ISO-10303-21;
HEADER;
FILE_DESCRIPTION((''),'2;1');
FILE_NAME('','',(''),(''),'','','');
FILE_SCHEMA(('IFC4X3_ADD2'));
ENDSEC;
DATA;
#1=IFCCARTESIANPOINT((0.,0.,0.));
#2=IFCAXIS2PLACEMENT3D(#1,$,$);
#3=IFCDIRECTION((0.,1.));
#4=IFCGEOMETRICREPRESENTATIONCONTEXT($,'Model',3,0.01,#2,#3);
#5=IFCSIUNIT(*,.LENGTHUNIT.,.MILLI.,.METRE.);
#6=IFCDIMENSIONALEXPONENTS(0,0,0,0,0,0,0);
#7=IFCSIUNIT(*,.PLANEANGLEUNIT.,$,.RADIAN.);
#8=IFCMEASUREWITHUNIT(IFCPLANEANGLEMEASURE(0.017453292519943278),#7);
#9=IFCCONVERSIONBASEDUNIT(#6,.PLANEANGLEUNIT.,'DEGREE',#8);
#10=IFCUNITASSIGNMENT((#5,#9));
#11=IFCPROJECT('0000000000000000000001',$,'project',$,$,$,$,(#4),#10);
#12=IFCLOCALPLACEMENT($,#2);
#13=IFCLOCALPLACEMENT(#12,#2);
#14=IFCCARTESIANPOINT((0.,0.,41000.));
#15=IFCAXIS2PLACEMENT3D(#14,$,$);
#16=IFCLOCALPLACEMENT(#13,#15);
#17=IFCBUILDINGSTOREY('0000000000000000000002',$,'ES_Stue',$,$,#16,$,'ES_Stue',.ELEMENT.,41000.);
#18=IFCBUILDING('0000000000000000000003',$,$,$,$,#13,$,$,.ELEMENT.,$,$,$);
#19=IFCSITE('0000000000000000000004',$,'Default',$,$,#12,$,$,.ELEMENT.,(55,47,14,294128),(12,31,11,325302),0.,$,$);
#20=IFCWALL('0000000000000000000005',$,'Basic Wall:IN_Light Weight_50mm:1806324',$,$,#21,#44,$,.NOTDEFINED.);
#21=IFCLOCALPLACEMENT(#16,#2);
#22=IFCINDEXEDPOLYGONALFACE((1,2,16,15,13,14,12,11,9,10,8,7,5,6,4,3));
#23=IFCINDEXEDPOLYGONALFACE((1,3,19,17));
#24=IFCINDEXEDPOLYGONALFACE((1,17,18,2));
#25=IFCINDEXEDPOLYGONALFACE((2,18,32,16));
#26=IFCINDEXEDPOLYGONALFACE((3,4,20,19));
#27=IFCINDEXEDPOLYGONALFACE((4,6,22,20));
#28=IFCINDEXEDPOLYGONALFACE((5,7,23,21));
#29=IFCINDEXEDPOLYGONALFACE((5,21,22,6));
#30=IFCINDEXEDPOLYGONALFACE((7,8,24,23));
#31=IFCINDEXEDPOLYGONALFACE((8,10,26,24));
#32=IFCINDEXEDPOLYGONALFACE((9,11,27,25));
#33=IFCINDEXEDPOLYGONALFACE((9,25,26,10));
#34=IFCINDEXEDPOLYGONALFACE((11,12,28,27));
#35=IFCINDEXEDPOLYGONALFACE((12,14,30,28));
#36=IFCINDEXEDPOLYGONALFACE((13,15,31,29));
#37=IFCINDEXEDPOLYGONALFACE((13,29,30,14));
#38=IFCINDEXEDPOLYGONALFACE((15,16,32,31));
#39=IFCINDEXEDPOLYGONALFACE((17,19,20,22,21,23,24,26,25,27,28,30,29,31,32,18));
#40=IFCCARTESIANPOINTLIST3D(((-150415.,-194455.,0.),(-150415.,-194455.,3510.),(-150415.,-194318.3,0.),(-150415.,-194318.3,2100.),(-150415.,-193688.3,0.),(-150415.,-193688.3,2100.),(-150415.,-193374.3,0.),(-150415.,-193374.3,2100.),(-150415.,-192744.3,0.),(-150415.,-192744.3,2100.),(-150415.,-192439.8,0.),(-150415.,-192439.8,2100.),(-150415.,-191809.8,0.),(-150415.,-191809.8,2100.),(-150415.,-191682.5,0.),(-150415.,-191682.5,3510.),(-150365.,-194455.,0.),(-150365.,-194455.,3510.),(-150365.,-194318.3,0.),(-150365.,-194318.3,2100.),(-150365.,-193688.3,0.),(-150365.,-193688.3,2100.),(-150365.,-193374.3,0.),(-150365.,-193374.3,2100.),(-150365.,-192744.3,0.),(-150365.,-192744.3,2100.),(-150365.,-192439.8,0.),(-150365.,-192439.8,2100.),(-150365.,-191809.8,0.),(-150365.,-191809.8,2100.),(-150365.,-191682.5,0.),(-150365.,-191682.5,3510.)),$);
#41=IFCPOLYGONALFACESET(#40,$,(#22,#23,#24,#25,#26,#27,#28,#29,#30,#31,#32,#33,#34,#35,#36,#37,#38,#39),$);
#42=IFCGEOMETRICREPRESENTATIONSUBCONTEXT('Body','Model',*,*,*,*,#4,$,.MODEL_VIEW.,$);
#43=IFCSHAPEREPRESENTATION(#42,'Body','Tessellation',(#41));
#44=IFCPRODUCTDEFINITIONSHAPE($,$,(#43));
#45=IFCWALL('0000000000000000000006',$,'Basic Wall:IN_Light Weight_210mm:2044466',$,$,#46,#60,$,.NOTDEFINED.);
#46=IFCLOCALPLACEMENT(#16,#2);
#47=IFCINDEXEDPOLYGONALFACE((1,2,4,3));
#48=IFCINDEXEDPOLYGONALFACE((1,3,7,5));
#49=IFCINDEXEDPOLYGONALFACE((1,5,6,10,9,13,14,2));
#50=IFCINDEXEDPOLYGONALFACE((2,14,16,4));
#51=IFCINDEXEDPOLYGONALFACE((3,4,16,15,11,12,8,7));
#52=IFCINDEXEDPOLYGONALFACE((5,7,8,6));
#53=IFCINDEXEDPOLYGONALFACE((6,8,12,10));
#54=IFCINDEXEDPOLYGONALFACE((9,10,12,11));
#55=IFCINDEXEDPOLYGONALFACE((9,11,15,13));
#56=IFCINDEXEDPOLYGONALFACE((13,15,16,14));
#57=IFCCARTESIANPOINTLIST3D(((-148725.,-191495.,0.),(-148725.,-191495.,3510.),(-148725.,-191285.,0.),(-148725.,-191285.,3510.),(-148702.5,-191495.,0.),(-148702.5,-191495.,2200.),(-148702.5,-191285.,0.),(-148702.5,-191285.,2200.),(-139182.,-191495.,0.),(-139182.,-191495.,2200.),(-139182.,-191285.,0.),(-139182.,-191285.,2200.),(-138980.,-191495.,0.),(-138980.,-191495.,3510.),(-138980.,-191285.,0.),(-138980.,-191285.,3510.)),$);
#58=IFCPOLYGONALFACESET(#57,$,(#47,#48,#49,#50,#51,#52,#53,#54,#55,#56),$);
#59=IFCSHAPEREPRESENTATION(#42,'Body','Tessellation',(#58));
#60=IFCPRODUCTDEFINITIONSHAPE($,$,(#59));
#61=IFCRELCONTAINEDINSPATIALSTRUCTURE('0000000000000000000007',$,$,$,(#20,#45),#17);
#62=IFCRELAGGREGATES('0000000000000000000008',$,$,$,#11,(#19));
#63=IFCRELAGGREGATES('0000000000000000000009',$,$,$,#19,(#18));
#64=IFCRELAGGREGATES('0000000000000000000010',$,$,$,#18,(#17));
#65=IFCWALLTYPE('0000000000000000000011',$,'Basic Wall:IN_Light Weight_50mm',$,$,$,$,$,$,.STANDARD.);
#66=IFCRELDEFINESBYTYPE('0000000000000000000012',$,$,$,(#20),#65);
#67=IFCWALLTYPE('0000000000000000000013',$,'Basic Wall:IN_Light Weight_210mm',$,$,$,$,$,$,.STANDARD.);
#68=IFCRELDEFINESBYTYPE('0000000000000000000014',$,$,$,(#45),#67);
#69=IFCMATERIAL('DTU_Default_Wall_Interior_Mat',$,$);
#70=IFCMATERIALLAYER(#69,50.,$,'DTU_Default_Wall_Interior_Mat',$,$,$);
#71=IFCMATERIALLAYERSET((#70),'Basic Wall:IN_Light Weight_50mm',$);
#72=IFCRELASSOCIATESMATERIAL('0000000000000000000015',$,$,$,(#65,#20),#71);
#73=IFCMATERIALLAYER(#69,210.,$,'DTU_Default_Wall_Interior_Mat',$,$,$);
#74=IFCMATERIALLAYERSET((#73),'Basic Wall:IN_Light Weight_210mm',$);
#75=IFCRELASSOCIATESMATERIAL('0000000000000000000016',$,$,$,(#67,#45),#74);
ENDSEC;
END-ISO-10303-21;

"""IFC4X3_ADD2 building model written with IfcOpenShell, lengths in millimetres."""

from ifc_helpers import new_model, entity, si_unit, converted_unit, direction, frame, frame_2d, origin, place, context, subcontext, project, spatial, rectangle, extrude, material, layer, layer_set, type_object, element, save


model = new_model("IFC4X3_ADD2")

# Units and contexts
model_context = context("Model", 3, precision=0.01, world=origin(), true_north=direction((0.0, 1.0)))
body_context = subcontext(model_context, "Body", "Model", "MODEL_VIEW")
ifc_project = project(units=[si_unit("LENGTHUNIT", "METRE", prefix="MILLI"), converted_unit("PLANEANGLEUNIT", "DEGREE", entity("IfcPlaneAngleMeasure", 0.017453292519943278), si_unit("PLANEANGLEUNIT", "RADIAN"), dimensions=[0, 0, 0, 0, 0, 0, 0])], contexts=[model_context])

# Site, building, storey
site_placement = place(None, origin())
site = spatial("IfcSite", under=ifc_project, at=site_placement, Name="Default", CompositionType="ELEMENT", RefLatitude=(55, 47, 14, 294128), RefLongitude=(12, 31, 11, 325302), RefElevation=0.0)
building_placement = place(site_placement, origin())
building = spatial("IfcBuilding", under=site, at=building_placement, CompositionType="ELEMENT")
storey_placement = place(building_placement, frame((0.0, 0.0, 41000.0)))
storey = spatial("IfcBuildingStorey", under=building, at=storey_placement, Name="ES_Stue", LongName="ES_Stue", CompositionType="ELEMENT", Elevation=41000.0)

# Shared definitions
ifc_material_1 = material(Name="DTU_Default_Wall_Interior_Mat")

# Shared definitions
ifc_layer_1 = layer(ifc_material_1, 50.0, Name="DTU_Default_Wall_Interior_Mat")
ifc_layer_set_1 = layer_set([ifc_layer_1], Name="Basic Wall:IN_Light Weight_50mm")
wall_type_1 = type_object("IfcWallType", Name="Basic Wall:IN_Light Weight_50mm", PredefinedType="STANDARD", material=ifc_layer_set_1)

# Wall, openings
wall_1_placement = place(storey_placement, frame((-150390.0, -194455.0, 0.0), z_axis=(0.0, 0.0, 1.0), x_axis=(0.0, 1.0, 0.0)))
wall_1 = element("IfcWall", 1, at=wall_1_placement, inside=storey, type_object=wall_type_1, material=ifc_layer_set_1, Name="Basic Wall:IN_Light Weight_50mm:1806324", PredefinedType="NOTDEFINED", context=body_context, shape_type="SweptSolid", body=[
    extrude(rectangle(XDim=2772.5, YDim=50.0, at=frame_2d((1386.3, 0.0), x_axis=(1.0, 0.0))), origin(), (0.0, 0.0, 1.0), 3510.0),
])
opening_1_placement = place(wall_1_placement, frame((2015.2, -25.0, 0.0)))
element("IfcOpeningElement", 2, at=opening_1_placement, cuts=wall_1, PredefinedType="OPENING", context=body_context, shape_type="SweptSolid", body=[
    extrude(rectangle(XDim=2100.0, YDim=630.0, at=frame_2d((1050.0, 315.0), x_axis=(1.0, 0.0))), frame((0.0, 0.0, 0.0), z_axis=(0.0, 1.0, 0.0), x_axis=(0.0, 0.0, 1.0)), (0.0, 0.0, 1.0), 50.0),
])
opening_2_placement = place(wall_1_placement, frame((1080.7, -25.0, 0.0)))
element("IfcOpeningElement", 3, at=opening_2_placement, cuts=wall_1, PredefinedType="OPENING", context=body_context, shape_type="SweptSolid", body=[
    extrude(rectangle(XDim=2100.0, YDim=630.0, at=frame_2d((1050.0, 315.0), x_axis=(1.0, 0.0))), frame((0.0, 0.0, 0.0), z_axis=(0.0, 1.0, 0.0), x_axis=(0.0, 0.0, 1.0)), (0.0, 0.0, 1.0), 50.0),
])
opening_3_placement = place(wall_1_placement, frame((136.7, -25.0, 0.0)))
element("IfcOpeningElement", 4, at=opening_3_placement, cuts=wall_1, PredefinedType="OPENING", context=body_context, shape_type="SweptSolid", body=[
    extrude(rectangle(XDim=2100.0, YDim=630.0, at=frame_2d((1050.0, 315.0), x_axis=(1.0, 0.0))), frame((0.0, 0.0, 0.0), z_axis=(0.0, 1.0, 0.0), x_axis=(0.0, 0.0, 1.0)), (0.0, 0.0, 1.0), 50.0),
])

# Wall, opening
ifc_layer_2 = layer(ifc_material_1, 210.0, Name="DTU_Default_Wall_Interior_Mat")
ifc_layer_set_2 = layer_set([ifc_layer_2], Name="Basic Wall:IN_Light Weight_210mm")
wall_type_2 = type_object("IfcWallType", Name="Basic Wall:IN_Light Weight_210mm", PredefinedType="STANDARD", material=ifc_layer_set_2)
wall_2_placement = place(storey_placement, frame((-148725.0, -191390.0, 0.0)))
wall_2 = element("IfcWall", 5, at=wall_2_placement, inside=storey, type_object=wall_type_2, material=ifc_layer_set_2, Name="Basic Wall:IN_Light Weight_210mm:2044466", PredefinedType="NOTDEFINED", context=body_context, shape_type="SweptSolid", body=[
    extrude(rectangle(XDim=9745.0, YDim=210.0, at=frame_2d((4872.5, 0.0), x_axis=(1.0, 0.0))), origin(), (0.0, 0.0, 1.0), 3510.0),
])
opening_4_placement = place(wall_2_placement, frame((22.5, -257.4, 0.0)))
element("IfcOpeningElement", 6, at=opening_4_placement, cuts=wall_2, PredefinedType="OPENING", context=body_context, shape_type="SweptSolid", body=[
    extrude(rectangle(XDim=2200.0, YDim=9520.5, at=frame_2d((0.0, 0.0), x_axis=(1.0, 0.0))), frame((4760.3, 0.0, 1100.0), z_axis=(0.0, 1.0, 0.0), x_axis=(0.0, 0.0, 1.0)), (0.0, 0.0, 1.0), 514.8),
])

save(model, "model.ifc")
